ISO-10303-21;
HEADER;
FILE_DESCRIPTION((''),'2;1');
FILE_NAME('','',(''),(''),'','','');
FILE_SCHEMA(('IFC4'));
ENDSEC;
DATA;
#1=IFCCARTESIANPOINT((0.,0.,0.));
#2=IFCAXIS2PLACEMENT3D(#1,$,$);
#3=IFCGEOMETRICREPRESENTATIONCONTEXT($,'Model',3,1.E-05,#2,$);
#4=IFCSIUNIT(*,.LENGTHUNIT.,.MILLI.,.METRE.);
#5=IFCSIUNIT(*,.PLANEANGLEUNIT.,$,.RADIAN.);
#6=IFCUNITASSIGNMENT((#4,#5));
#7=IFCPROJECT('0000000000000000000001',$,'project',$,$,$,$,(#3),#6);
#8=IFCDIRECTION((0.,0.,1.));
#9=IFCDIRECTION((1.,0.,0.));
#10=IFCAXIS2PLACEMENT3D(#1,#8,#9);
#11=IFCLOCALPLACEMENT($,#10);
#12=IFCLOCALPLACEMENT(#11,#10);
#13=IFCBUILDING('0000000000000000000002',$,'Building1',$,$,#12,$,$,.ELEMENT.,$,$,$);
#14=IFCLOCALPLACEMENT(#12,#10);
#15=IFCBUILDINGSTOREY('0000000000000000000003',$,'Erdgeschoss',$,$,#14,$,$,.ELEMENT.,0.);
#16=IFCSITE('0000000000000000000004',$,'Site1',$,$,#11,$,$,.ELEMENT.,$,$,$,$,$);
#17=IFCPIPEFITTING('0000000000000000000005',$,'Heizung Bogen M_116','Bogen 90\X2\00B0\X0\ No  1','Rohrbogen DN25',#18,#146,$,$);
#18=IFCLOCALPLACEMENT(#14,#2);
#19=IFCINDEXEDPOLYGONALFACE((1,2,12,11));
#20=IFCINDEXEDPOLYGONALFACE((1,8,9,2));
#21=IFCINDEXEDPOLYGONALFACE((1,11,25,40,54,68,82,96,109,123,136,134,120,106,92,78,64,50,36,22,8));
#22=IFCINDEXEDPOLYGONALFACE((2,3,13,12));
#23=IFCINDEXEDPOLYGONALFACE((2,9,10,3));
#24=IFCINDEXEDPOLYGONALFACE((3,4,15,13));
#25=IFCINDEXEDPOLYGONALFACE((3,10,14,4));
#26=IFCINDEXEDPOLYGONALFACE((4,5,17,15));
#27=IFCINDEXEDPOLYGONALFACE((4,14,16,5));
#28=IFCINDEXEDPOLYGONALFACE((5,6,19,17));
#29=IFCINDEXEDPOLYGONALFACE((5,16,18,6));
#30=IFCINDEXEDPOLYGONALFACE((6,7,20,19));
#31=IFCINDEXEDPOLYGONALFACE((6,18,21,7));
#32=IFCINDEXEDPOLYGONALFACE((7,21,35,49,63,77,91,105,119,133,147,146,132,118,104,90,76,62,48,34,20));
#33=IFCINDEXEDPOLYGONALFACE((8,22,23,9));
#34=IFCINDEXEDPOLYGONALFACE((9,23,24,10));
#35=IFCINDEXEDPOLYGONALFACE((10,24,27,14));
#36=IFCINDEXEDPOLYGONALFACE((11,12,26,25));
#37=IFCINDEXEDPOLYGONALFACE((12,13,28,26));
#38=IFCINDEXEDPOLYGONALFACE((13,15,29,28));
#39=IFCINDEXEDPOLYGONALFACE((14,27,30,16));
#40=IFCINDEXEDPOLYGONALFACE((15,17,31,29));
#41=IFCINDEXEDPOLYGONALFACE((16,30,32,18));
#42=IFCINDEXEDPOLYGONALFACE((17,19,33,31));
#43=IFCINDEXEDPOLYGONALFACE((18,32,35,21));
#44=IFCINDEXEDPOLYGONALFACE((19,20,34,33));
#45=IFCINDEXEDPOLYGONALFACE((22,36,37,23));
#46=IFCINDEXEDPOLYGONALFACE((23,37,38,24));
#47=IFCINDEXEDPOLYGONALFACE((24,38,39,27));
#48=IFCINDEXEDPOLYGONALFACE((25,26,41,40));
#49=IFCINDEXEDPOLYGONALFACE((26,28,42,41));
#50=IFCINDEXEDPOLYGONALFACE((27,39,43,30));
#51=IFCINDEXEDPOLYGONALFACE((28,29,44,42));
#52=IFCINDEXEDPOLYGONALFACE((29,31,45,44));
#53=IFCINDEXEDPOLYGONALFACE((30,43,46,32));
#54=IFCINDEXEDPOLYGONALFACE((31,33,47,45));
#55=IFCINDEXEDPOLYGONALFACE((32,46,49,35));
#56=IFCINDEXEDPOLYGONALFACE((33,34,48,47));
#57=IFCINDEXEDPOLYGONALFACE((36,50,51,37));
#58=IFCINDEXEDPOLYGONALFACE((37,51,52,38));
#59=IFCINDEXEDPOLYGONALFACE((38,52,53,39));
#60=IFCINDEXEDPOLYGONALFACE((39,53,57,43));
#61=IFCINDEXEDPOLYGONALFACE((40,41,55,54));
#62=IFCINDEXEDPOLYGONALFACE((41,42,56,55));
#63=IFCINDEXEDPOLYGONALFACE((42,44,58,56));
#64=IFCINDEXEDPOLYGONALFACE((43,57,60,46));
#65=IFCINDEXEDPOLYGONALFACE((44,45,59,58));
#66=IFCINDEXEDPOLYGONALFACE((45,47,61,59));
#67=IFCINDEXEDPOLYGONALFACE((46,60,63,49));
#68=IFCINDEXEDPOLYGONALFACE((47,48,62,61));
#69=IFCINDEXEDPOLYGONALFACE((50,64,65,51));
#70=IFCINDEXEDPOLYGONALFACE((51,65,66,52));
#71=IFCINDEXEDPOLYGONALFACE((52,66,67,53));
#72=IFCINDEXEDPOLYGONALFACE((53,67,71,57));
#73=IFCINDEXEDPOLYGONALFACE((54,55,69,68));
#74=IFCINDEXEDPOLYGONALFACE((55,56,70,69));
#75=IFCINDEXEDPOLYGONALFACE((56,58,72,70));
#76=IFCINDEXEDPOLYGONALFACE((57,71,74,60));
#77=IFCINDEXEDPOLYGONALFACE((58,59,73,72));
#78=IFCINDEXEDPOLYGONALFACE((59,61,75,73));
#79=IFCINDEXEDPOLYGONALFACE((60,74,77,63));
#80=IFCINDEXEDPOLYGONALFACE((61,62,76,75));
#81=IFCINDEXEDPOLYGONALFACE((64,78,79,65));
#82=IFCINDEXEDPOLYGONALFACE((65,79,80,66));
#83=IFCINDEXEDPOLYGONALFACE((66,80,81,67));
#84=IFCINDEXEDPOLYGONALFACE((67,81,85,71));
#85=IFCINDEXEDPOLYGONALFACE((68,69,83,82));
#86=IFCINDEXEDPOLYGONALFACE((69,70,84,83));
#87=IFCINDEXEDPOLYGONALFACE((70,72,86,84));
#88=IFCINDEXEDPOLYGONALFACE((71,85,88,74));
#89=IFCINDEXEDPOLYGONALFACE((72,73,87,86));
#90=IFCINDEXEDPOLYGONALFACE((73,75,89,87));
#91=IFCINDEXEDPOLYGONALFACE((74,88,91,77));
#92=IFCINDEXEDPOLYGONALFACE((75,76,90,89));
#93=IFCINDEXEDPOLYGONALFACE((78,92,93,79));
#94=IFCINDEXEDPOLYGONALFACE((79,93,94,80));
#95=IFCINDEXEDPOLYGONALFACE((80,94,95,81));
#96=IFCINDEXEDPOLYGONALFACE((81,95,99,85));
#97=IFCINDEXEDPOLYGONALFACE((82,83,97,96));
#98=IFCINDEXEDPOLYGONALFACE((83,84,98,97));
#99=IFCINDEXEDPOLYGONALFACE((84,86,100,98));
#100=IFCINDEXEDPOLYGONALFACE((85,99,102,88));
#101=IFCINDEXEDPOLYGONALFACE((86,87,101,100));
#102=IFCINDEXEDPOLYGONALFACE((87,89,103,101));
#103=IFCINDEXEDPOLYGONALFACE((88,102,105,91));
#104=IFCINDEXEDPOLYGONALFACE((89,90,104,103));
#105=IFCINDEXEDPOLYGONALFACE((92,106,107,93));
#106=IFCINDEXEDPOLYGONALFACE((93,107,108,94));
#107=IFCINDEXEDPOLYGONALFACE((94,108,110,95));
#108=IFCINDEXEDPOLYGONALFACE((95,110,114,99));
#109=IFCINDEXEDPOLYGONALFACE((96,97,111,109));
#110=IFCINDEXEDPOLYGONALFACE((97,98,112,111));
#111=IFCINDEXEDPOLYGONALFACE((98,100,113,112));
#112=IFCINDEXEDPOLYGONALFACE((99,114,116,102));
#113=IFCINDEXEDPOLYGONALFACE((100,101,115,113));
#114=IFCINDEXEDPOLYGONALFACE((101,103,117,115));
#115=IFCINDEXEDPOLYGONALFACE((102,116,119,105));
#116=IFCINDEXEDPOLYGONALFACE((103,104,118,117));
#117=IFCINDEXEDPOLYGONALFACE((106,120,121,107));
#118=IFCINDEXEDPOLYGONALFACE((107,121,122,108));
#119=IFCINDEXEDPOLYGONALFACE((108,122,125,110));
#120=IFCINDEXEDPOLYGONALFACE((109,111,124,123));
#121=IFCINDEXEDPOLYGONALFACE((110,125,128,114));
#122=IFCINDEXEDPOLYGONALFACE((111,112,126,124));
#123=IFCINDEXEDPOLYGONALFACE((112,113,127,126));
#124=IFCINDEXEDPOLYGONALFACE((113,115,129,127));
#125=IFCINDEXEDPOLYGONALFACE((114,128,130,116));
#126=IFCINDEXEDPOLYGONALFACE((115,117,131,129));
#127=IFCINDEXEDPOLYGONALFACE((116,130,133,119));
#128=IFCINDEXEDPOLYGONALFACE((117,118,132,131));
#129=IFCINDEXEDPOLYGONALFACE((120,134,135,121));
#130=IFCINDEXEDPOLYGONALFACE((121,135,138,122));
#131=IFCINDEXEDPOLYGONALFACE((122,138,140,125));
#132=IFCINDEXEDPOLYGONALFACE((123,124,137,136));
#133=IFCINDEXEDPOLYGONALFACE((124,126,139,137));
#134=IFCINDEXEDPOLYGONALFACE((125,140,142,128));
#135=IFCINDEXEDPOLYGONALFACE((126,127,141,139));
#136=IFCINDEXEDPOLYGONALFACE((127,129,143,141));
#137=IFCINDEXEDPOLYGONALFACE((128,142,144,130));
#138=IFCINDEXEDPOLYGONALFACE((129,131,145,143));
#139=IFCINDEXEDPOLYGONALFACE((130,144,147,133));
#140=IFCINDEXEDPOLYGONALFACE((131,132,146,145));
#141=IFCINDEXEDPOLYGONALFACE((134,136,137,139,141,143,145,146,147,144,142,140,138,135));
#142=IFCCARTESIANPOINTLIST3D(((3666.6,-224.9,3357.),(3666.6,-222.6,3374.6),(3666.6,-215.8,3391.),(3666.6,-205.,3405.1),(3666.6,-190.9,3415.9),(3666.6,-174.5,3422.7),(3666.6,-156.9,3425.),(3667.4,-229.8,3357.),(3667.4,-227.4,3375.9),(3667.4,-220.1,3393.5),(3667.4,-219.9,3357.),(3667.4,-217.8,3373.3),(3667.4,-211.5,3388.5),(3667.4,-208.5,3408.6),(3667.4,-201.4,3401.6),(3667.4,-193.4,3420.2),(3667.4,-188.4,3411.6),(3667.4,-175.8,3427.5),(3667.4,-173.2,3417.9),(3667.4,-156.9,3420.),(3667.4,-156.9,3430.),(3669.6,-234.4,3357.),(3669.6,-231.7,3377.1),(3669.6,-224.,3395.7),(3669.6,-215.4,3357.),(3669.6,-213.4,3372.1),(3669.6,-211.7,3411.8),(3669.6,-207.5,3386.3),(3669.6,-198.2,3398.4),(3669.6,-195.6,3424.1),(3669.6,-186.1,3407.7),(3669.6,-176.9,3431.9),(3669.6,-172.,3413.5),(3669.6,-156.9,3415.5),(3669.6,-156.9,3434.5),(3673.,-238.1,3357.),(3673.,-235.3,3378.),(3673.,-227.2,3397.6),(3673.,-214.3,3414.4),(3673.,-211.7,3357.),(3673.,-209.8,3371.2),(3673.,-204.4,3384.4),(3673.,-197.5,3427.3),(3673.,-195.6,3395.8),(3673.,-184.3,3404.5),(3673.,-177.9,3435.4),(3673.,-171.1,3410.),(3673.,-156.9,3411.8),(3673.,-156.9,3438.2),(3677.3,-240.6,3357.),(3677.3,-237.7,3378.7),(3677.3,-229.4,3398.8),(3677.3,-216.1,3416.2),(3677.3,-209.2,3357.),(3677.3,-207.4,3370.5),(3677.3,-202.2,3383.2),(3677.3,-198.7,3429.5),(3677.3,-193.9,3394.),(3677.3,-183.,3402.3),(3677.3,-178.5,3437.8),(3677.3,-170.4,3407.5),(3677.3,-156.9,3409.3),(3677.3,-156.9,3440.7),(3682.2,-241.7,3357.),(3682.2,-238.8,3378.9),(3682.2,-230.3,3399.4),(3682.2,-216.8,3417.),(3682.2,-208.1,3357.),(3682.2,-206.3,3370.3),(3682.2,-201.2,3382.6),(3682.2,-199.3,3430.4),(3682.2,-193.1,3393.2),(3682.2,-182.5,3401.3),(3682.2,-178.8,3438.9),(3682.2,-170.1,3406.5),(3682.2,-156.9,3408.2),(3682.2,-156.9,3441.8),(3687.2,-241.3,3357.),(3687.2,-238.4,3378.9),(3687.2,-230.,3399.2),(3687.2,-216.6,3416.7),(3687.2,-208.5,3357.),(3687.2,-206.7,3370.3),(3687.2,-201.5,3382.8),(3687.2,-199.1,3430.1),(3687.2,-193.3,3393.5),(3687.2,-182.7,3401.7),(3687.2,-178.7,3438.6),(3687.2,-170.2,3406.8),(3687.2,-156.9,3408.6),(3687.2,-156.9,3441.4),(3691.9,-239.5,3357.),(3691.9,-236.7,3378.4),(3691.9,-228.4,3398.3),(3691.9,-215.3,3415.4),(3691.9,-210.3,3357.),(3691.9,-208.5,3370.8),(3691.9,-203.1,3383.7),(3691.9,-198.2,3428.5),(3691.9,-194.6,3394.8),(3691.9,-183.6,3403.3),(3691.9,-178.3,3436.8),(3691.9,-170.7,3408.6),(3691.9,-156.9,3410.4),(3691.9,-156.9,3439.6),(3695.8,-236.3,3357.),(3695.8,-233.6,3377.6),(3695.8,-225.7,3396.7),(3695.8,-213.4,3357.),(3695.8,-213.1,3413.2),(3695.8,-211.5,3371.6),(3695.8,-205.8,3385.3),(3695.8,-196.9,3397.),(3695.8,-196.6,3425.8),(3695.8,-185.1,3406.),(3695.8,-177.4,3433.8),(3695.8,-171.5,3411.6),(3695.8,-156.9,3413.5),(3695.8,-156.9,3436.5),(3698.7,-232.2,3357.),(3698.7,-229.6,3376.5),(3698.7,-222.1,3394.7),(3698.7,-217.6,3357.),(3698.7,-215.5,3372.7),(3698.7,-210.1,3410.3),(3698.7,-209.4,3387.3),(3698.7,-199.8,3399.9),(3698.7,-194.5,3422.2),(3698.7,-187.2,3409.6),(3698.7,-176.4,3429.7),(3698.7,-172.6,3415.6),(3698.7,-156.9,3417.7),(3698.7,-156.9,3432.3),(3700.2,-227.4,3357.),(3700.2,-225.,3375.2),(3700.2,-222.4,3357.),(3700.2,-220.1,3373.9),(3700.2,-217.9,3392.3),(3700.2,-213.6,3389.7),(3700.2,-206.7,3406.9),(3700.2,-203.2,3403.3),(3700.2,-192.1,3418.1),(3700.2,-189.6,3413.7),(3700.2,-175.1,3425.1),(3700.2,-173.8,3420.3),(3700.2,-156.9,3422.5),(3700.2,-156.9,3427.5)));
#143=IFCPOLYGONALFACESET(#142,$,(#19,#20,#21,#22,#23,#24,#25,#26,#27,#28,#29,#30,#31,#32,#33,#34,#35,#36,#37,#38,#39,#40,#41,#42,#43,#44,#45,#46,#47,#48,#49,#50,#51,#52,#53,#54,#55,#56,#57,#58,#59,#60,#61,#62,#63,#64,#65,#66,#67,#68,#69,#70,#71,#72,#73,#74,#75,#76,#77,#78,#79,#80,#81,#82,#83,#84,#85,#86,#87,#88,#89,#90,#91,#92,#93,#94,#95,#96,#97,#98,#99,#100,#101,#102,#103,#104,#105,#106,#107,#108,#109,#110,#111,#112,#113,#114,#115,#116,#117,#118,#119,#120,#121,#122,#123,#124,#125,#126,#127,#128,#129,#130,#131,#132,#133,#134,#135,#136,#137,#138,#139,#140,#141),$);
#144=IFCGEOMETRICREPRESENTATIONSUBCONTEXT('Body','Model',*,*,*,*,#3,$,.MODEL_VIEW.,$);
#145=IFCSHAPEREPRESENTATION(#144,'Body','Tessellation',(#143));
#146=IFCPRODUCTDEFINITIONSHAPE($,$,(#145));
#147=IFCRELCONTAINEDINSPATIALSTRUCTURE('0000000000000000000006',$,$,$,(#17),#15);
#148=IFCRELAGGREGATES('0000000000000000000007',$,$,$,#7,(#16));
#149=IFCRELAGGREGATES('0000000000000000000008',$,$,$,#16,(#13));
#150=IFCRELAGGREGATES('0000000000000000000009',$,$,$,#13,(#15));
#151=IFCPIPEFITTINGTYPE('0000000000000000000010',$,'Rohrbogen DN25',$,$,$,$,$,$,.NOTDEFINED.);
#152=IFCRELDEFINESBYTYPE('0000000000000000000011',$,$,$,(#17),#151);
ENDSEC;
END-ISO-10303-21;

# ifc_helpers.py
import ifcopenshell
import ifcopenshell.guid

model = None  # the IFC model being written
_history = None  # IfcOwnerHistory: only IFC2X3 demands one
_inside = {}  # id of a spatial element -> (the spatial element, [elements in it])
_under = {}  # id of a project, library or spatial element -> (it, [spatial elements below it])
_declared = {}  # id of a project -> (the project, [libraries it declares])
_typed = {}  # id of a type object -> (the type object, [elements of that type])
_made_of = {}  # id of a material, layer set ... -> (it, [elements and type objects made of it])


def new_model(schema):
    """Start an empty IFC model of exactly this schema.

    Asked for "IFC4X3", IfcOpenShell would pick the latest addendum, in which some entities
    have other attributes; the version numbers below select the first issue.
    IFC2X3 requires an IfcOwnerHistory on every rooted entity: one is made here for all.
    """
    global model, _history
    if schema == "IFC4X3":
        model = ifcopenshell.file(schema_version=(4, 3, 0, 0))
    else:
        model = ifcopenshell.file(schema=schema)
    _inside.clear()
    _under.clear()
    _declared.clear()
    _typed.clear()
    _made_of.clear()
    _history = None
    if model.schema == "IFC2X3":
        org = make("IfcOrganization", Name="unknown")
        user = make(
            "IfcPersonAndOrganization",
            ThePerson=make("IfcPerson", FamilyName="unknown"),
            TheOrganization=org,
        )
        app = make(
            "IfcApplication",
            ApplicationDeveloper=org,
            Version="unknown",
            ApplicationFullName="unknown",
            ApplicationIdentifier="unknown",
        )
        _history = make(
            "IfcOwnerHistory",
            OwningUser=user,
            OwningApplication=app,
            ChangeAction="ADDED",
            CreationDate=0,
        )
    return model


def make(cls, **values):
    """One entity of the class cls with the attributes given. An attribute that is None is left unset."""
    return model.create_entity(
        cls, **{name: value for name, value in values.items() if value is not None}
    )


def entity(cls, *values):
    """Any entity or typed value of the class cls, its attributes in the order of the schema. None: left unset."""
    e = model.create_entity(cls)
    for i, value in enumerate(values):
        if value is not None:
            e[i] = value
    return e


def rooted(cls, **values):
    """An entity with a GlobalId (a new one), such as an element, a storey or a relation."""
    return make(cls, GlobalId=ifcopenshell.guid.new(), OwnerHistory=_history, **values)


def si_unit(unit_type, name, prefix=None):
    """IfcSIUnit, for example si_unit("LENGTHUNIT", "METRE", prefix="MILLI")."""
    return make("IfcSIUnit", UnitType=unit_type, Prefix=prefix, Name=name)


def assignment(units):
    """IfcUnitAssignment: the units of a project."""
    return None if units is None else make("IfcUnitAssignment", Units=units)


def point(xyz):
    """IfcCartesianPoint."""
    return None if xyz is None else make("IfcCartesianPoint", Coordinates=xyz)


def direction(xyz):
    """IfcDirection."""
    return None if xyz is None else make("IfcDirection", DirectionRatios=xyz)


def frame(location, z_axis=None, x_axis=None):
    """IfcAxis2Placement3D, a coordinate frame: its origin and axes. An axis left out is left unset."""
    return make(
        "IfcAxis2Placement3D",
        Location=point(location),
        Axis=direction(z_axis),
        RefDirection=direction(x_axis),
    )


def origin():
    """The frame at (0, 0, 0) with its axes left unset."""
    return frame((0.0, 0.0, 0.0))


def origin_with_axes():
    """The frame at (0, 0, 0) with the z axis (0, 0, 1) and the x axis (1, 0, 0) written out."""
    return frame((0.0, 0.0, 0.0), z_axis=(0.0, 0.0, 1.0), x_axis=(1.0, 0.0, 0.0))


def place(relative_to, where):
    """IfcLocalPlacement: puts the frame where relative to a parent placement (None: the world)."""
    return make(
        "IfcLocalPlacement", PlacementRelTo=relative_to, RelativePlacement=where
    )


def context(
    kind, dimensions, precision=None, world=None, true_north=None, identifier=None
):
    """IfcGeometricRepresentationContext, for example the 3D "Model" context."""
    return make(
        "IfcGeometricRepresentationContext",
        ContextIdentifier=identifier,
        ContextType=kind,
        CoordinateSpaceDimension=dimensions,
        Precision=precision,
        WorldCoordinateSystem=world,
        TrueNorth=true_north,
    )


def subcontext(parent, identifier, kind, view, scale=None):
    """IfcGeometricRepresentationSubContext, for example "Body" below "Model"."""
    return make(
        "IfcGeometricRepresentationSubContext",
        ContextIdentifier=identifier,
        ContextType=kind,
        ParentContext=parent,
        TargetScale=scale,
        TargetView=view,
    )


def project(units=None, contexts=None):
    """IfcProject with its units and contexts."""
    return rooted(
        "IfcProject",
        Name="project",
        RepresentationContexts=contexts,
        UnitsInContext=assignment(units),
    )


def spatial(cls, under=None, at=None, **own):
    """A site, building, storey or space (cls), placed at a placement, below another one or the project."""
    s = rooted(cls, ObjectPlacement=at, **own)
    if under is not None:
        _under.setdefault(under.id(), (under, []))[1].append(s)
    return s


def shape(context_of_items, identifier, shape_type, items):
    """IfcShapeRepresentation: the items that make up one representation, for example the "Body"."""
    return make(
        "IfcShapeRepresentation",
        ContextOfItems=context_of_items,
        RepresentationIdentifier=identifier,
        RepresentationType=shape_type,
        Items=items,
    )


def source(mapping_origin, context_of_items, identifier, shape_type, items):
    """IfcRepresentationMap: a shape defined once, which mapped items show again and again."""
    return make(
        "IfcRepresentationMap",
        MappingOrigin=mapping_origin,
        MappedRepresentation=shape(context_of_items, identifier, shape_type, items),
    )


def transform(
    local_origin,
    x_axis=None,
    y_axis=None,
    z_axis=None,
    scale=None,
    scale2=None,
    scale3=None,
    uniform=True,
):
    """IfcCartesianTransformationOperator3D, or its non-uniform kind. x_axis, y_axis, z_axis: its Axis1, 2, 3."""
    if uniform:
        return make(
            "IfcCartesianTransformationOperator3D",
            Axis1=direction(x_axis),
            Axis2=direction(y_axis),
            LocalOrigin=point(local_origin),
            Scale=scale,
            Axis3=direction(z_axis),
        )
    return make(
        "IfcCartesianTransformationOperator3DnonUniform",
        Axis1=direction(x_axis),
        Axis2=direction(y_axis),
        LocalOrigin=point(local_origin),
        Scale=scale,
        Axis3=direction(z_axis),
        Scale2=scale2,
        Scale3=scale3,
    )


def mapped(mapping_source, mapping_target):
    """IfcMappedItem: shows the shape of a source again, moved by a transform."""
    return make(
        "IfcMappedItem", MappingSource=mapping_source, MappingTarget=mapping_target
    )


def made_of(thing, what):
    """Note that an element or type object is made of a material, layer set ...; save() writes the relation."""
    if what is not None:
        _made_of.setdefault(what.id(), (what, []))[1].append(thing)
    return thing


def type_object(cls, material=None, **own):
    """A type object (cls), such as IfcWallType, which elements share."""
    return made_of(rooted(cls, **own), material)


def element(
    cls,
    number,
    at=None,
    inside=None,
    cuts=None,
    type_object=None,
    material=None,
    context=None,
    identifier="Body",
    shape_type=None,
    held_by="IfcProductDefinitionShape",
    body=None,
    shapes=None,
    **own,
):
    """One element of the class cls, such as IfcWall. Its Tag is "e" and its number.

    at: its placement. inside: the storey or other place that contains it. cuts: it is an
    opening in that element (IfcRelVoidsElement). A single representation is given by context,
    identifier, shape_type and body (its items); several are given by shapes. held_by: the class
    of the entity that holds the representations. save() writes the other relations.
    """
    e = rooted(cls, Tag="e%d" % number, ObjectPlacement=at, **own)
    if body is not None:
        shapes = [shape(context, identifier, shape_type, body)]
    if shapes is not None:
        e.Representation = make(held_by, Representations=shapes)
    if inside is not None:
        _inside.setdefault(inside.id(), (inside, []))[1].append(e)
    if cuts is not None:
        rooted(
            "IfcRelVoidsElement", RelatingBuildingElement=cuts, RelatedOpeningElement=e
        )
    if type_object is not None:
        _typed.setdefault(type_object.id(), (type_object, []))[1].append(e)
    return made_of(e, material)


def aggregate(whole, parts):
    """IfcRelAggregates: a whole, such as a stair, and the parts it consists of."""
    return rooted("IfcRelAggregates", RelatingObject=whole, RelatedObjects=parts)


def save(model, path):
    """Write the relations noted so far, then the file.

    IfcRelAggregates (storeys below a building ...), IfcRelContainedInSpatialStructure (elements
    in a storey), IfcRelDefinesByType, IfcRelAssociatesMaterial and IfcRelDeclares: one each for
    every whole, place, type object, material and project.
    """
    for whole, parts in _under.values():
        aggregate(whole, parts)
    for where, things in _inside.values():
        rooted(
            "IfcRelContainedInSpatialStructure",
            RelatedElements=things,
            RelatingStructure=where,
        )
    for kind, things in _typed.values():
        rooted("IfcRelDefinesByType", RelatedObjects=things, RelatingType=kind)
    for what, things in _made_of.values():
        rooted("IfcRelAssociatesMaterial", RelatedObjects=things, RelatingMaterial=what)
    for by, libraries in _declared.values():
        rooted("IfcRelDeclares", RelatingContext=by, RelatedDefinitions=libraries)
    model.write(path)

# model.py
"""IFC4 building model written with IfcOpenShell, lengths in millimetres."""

from ifc_helpers import new_model, entity, si_unit, frame, origin, origin_with_axes, place, context, subcontext, project, spatial, source, transform, mapped, type_object, element, save


model = new_model("IFC4")

# Units and contexts
model_context = context("Model", 3, precision=1e-05, world=origin())
body_context = subcontext(model_context, "Body", "Model", "MODEL_VIEW")
ifc_project = project(units=[si_unit("LENGTHUNIT", "METRE", prefix="MILLI"), si_unit("PLANEANGLEUNIT", "RADIAN")], contexts=[model_context])

# Site, building, storey
site_placement = place(None, origin_with_axes())
site = spatial("IfcSite", under=ifc_project, at=site_placement, Name="Site1", CompositionType="ELEMENT")
building_placement = place(site_placement, origin_with_axes())
building = spatial("IfcBuilding", under=site, at=building_placement, Name="Building1", CompositionType="ELEMENT")
storey_placement = place(building_placement, origin_with_axes())
storey = spatial("IfcBuildingStorey", under=building, at=storey_placement, Name="Erdgeschoss", CompositionType="ELEMENT", Elevation=0.0)

# Pipe fitting
pipe_fitting_type_1 = type_object("IfcPipeFittingType", Name="Rohrbogen DN25", PredefinedType="NOTDEFINED")
shared_shape_1 = source(origin_with_axes(), body_context, "Body", "SolidModel", [
    entity("IfcRevolvedAreaSolid", entity("IfcCircleProfileDef", "AREA", None, entity("IfcAxis2Placement2D", entity("IfcCartesianPoint", [0.0, 0.0]), entity("IfcDirection", [1.0, 0.0])), 16.9), entity("IfcAxis2Placement3D", entity("IfcCartesianPoint", [-42.4, 0.0, 25.6]), entity("IfcDirection", [1.0, 0.0, 0.0]), entity("IfcDirection", [0.0, -1.0, 0.0])), entity("IfcAxis1Placement", entity("IfcCartesianPoint", [0.0, 68.0, 0.0]), entity("IfcDirection", [-1.0, 0.0, 0.0])), 1.570796),
])
pipe_fitting_1_placement = place(storey_placement, frame((3683.5, -199.3, 3399.4), z_axis=(0.0, 0.0, 1.0), x_axis=(1.0, 0.0, 0.0)))
element("IfcPipeFitting", 1, at=pipe_fitting_1_placement, inside=storey, type_object=pipe_fitting_type_1, Name="Heizung Bogen M_116", Description="Bogen 90° No  1", ObjectType="Rohrbogen DN25", context=body_context, shape_type="MappedRepresentation", body=[
    mapped(shared_shape_1, transform((0.0, 0.0, 0.0), x_axis=(0.0, -1.0, 0.0), y_axis=(1.0, 0.0, 0.0), z_axis=(0.0, 0.0, 1.0), scale=1.0)),
])

save(model, "model.ifc")
